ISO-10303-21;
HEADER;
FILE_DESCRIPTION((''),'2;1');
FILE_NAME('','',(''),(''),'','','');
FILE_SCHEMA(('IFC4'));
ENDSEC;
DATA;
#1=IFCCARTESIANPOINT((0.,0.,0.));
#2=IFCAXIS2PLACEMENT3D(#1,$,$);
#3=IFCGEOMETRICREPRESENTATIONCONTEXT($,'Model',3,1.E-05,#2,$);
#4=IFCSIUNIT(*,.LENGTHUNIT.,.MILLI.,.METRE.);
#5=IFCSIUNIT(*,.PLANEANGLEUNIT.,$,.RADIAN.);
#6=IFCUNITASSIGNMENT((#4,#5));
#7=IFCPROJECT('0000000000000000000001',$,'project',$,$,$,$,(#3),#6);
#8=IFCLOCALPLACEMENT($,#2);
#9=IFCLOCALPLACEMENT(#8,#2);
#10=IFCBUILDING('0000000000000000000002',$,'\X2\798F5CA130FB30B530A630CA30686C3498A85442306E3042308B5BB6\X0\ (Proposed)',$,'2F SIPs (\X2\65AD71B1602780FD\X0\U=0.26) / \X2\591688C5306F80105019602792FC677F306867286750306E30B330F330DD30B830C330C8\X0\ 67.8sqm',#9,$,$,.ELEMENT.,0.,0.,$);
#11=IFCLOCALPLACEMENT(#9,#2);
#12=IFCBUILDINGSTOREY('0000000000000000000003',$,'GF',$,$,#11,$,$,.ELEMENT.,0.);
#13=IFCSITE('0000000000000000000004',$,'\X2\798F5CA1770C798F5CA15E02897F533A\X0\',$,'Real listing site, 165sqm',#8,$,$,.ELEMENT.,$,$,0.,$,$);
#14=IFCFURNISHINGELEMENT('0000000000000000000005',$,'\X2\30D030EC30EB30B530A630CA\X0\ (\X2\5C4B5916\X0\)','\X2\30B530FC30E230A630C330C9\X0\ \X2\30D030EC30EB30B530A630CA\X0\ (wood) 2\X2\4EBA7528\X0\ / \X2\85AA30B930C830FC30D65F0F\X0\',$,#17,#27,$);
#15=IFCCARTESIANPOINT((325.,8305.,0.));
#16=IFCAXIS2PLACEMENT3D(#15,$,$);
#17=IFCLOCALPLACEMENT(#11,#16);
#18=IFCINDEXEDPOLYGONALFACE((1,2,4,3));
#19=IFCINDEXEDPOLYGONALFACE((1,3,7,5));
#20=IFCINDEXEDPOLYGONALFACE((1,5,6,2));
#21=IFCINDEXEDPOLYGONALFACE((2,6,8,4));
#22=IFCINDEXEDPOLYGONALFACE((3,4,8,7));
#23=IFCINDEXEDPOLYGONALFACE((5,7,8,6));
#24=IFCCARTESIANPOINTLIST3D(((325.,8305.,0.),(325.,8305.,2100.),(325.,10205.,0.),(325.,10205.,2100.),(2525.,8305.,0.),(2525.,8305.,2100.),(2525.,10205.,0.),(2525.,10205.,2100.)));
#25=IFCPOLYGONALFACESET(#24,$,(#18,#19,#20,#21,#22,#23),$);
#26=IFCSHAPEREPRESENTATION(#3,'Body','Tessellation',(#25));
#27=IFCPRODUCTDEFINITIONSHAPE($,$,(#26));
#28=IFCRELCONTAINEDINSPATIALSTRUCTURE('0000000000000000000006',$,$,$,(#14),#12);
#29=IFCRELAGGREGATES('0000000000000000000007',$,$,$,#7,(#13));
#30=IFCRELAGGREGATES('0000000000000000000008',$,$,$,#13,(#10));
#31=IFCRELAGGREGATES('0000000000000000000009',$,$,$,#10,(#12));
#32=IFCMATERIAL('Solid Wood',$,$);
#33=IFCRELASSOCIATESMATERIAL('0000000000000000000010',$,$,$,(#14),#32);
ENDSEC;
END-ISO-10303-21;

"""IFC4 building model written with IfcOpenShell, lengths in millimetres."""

from ifc_helpers import new_model, si_unit, frame, frame_2d, origin, place, context, project, spatial, rectangle, extrude, material, element, save


model = new_model("IFC4")

# Units and contexts
model_context = context("Model", 3, precision=1e-05, world=origin())
ifc_project = project(units=[si_unit("LENGTHUNIT", "METRE", prefix="MILLI"), si_unit("PLANEANGLEUNIT", "RADIAN")], contexts=[model_context])

# Site, building, storey
site_placement = place(None, origin())
site = spatial("IfcSite", under=ifc_project, at=site_placement, Name="福岡県福岡市西区", ObjectType="Real listing site, 165sqm", CompositionType="ELEMENT", RefElevation=0.0)
building_placement = place(site_placement, origin())
building = spatial("IfcBuilding", under=site, at=building_placement, Name="福岡・サウナと水風呂のある家 (Proposed)", ObjectType="2F SIPs (断熱性能U=0.26) / 外装は耐候性鋼板と木材のコンポジット 67.8sqm", CompositionType="ELEMENT", ElevationOfRefHeight=0.0, ElevationOfTerrain=0.0)
storey_placement = place(building_placement, origin())
storey = spatial("IfcBuildingStorey", under=building, at=storey_placement, Name="GF", CompositionType="ELEMENT", Elevation=0.0)

# Shared definitions
ifc_material_1 = material(Name="Solid Wood")

# Furnishing element
furnishing_placement = place(storey_placement, frame((325.0, 8305.0, 0.0)))
element("IfcFurnishingElement", 1, at=furnishing_placement, inside=storey, material=ifc_material_1, Name="バレルサウナ (屋外)", Description="サーモウッド バレルサウナ (wood) 2人用 / 薪ストーブ式", context=model_context, shape_type="SweptSolid", body=[
    extrude(rectangle(XDim=2200.0, YDim=1900.0, at=frame_2d((1100.0, 950.0))), frame((325.0, 8305.0, 0.0)), (0.0, 0.0, 1.0), 2100.0),
])

save(model, "model.ifc")
